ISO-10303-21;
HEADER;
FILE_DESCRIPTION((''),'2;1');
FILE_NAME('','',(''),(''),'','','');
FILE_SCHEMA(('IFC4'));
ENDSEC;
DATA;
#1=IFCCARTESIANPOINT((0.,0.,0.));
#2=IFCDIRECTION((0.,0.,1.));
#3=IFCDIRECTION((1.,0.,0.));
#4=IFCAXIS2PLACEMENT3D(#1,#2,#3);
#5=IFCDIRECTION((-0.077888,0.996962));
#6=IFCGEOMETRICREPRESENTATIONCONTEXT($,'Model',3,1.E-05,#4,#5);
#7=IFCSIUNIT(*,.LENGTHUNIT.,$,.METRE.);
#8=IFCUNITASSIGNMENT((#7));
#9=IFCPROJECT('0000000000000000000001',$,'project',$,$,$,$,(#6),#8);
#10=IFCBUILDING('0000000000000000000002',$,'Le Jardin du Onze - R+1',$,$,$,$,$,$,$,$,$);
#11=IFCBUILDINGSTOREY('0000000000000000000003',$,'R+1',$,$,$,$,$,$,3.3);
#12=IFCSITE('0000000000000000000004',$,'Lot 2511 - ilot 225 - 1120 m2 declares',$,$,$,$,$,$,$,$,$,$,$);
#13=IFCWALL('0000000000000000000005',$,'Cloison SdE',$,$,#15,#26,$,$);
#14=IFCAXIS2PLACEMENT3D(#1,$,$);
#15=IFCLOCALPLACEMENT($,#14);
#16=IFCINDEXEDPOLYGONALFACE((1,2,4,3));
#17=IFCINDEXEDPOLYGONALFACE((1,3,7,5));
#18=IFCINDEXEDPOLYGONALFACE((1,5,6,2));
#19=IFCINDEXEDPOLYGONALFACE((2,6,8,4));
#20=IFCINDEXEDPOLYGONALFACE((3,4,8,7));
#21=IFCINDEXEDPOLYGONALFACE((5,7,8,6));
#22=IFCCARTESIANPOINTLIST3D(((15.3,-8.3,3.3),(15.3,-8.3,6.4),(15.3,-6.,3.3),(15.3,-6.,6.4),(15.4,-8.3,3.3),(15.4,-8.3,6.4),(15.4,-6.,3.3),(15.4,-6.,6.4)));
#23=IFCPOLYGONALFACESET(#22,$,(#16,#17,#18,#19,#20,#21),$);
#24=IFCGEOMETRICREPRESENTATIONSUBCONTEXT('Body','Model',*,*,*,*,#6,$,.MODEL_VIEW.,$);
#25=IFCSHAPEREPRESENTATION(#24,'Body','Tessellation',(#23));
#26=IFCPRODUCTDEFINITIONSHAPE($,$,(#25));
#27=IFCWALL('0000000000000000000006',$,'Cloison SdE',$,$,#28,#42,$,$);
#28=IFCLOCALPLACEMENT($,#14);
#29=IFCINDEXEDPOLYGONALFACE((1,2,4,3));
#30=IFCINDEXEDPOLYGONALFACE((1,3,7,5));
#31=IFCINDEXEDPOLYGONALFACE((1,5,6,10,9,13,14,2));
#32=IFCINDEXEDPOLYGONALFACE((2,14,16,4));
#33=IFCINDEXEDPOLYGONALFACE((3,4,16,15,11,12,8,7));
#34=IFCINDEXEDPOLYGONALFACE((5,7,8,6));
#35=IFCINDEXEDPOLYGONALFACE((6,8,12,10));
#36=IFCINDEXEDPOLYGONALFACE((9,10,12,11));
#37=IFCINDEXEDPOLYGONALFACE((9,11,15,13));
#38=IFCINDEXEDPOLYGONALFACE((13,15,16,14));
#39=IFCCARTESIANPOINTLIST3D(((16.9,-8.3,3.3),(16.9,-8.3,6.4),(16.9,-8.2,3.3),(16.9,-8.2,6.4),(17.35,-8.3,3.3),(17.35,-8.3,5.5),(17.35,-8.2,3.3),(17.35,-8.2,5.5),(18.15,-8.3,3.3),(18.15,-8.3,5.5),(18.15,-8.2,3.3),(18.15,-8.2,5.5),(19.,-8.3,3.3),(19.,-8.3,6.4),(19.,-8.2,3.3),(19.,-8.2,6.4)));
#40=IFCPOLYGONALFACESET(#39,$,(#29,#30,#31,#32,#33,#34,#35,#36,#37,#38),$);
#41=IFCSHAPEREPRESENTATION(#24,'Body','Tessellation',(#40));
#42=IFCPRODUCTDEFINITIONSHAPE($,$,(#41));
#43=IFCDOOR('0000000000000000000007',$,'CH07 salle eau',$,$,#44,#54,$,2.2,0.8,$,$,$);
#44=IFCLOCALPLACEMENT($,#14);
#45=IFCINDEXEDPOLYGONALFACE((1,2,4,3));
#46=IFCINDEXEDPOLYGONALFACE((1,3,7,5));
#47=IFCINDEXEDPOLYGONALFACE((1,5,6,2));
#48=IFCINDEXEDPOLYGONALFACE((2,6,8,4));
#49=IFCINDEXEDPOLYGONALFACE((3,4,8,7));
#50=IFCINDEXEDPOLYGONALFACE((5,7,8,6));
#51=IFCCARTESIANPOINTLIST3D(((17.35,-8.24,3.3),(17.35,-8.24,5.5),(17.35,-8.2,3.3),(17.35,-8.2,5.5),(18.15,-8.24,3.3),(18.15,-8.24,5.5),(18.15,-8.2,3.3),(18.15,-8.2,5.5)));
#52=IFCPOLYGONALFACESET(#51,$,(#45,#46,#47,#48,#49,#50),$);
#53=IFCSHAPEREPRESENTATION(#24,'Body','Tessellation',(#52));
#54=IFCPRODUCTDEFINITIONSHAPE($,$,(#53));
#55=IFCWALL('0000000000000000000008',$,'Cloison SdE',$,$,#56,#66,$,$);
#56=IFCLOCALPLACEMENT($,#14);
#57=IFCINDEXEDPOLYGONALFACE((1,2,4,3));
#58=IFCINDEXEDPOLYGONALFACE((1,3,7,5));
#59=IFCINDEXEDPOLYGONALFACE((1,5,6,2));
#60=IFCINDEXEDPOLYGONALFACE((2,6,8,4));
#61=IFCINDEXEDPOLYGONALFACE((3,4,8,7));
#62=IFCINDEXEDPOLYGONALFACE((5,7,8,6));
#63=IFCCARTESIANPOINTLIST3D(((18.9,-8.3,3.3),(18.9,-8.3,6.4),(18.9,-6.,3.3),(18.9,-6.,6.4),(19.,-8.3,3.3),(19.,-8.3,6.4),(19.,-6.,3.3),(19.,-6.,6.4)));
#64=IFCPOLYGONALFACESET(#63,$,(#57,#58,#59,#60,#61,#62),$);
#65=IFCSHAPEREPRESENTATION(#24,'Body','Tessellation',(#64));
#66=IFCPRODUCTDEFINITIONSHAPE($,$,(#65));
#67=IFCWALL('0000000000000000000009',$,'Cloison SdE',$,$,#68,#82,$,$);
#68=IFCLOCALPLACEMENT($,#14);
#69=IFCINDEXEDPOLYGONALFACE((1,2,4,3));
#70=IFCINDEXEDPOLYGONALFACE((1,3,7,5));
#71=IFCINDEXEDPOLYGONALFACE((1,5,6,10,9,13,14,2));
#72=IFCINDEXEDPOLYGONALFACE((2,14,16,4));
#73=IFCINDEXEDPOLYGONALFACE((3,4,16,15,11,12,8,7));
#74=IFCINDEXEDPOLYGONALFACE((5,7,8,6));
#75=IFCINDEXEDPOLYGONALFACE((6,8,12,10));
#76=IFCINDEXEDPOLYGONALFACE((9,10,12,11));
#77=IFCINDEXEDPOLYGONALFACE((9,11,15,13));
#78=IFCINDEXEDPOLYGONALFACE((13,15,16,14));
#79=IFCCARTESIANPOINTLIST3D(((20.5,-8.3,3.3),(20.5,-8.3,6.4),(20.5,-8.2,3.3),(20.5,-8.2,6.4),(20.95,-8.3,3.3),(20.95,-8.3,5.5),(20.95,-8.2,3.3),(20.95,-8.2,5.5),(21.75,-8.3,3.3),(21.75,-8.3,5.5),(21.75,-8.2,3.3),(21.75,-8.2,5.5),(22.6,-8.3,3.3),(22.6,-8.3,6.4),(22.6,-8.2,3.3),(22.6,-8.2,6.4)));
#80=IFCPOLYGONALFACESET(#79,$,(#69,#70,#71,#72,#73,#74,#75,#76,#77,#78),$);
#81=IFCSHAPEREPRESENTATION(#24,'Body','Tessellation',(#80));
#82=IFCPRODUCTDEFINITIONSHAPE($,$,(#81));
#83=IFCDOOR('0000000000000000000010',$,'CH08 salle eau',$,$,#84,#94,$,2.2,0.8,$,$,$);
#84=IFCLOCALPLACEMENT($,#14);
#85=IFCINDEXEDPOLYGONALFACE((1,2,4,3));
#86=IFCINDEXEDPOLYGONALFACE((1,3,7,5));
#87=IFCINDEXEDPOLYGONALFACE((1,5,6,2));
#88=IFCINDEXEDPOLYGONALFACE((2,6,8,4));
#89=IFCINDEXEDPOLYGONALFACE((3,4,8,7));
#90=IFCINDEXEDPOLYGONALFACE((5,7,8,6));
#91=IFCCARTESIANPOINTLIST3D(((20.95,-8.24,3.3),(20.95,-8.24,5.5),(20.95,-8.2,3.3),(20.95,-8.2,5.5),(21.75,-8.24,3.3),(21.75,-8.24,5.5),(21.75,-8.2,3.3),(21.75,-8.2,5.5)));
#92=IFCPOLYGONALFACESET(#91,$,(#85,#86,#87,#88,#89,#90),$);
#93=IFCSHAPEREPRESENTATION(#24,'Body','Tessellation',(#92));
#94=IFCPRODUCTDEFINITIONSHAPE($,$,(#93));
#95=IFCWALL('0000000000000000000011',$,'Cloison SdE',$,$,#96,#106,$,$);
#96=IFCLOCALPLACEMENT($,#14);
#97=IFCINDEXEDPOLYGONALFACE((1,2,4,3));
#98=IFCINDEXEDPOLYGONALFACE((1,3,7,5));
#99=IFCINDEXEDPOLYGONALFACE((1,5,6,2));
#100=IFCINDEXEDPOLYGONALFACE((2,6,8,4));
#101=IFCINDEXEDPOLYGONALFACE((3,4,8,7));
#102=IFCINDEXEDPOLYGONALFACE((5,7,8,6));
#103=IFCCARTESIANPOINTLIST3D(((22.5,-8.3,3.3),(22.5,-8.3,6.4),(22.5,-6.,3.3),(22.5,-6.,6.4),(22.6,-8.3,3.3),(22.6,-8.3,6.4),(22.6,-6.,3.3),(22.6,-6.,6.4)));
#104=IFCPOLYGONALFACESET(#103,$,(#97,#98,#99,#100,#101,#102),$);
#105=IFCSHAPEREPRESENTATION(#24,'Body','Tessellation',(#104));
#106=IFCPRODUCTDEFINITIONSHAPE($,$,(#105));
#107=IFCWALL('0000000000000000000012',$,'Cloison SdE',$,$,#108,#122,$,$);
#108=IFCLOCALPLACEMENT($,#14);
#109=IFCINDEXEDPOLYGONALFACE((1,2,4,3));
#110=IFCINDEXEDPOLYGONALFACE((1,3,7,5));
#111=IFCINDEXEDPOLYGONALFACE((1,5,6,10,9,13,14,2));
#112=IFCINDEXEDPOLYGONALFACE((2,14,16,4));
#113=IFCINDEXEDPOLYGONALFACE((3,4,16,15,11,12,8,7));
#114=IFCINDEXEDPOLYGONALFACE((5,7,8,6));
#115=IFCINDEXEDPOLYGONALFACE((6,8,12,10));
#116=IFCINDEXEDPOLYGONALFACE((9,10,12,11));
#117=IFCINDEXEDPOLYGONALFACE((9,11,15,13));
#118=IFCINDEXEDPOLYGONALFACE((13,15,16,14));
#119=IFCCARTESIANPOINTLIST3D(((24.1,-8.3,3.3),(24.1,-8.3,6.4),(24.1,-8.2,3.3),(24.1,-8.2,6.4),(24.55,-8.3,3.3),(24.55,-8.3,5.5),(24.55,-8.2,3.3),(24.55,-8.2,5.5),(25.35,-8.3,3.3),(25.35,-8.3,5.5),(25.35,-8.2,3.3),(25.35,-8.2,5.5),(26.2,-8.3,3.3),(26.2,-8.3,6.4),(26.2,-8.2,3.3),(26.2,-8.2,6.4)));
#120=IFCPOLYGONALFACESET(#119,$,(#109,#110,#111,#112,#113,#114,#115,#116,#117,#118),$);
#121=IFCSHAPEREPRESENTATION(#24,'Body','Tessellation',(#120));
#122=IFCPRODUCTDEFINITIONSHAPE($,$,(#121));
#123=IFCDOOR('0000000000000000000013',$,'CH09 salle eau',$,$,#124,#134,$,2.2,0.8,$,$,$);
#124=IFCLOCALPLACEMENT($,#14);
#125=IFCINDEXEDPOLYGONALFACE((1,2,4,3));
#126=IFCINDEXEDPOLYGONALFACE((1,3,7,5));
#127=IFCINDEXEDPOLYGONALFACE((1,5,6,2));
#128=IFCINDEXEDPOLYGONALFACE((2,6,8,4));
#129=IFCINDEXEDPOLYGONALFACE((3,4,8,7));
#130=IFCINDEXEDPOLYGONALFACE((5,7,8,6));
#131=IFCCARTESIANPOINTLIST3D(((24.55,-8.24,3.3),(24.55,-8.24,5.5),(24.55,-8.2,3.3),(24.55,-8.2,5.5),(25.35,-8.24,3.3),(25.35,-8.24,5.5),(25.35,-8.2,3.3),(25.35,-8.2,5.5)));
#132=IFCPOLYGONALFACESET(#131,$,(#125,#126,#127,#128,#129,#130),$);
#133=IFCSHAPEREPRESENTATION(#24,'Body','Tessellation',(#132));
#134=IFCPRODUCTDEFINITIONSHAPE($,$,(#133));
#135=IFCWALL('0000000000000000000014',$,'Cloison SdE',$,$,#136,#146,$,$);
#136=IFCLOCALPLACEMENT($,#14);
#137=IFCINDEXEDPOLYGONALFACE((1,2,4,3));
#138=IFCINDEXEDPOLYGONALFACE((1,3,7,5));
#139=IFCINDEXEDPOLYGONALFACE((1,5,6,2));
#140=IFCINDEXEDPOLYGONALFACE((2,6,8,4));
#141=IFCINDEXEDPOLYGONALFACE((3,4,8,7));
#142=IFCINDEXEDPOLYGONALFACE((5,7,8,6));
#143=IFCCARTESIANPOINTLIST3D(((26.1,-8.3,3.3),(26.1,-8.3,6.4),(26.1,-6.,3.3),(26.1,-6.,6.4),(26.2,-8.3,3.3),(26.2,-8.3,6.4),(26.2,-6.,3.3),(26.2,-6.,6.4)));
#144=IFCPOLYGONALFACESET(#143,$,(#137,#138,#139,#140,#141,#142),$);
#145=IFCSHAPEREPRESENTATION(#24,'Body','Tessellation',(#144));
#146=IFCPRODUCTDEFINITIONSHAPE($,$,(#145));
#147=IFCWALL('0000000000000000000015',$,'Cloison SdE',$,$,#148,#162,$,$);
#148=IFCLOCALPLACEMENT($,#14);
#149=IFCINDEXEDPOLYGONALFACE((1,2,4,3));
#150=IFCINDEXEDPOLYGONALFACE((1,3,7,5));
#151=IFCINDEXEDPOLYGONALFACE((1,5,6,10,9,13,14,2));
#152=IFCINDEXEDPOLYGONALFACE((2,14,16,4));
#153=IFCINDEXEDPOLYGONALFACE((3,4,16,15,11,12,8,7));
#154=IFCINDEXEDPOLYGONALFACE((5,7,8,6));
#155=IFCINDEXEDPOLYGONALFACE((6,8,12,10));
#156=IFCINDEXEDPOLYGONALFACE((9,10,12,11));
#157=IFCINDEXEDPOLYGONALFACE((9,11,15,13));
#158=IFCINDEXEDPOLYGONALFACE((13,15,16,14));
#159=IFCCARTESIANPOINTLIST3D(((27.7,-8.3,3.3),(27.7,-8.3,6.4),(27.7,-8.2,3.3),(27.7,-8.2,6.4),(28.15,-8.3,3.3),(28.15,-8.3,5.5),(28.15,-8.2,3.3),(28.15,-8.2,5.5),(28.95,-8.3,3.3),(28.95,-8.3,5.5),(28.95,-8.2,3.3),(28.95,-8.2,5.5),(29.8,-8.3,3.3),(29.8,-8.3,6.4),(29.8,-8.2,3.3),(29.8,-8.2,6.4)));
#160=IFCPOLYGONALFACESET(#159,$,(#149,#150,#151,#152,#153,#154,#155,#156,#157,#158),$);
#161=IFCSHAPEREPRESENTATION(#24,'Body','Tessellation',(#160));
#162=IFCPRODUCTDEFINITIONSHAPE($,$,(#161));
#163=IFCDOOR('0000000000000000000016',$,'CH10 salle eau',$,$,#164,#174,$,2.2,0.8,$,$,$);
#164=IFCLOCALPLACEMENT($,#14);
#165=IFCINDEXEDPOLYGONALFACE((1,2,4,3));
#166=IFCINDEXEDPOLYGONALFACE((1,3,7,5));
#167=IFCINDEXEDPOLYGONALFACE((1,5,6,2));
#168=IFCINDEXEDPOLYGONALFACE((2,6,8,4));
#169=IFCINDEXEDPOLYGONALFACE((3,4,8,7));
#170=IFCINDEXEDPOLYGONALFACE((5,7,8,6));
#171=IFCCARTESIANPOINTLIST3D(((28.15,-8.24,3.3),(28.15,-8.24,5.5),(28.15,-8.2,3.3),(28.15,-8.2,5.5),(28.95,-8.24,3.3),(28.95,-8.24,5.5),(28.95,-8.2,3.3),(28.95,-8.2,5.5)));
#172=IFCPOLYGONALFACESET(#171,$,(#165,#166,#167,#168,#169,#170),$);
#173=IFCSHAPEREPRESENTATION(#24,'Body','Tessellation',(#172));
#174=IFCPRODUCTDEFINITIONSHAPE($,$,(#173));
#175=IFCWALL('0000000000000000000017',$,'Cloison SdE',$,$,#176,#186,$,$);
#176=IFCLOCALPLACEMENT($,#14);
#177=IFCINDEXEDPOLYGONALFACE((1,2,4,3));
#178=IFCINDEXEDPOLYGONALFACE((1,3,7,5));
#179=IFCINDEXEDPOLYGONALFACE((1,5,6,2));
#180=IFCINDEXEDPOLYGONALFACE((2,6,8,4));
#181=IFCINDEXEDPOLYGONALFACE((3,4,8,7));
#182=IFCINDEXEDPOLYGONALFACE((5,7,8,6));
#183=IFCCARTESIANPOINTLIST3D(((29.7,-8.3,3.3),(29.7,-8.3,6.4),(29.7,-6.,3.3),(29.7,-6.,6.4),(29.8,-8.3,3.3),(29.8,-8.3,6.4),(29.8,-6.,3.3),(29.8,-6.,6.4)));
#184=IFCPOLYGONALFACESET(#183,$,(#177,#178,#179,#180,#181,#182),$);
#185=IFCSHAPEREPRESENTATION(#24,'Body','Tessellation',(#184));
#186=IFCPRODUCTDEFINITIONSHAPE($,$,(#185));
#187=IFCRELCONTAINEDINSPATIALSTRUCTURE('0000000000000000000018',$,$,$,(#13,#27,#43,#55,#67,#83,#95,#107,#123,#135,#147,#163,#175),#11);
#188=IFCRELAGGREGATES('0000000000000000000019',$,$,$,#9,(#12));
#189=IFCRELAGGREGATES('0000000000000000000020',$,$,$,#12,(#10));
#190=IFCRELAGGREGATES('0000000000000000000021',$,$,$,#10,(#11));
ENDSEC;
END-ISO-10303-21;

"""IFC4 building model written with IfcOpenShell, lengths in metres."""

from ifc_helpers import new_model, si_unit, direction, frame, origin_with_axes, place, context, subcontext, project, spatial, polyline, outline, extrude, element, fill, save


model = new_model("IFC4")

# Units and contexts
model_context = context("Model", 3, precision=1e-05, world=origin_with_axes(), true_north=direction((-0.077888, 0.996962)))
body_context = subcontext(model_context, "Body", "Model", "MODEL_VIEW")
ifc_project = project(units=[si_unit("LENGTHUNIT", "METRE")], contexts=[model_context])

# Site, building, storey
site = spatial("IfcSite", under=ifc_project, Name="Lot 2511 - ilot 225 - 1120 m2 declares")
building = spatial("IfcBuilding", under=site, Name="Le Jardin du Onze - R+1")
storey = spatial("IfcBuildingStorey", under=building, Name="R+1", Elevation=3.3)

# Wall
wall_1_placement = place(None, origin_with_axes())
element("IfcWall", 1, at=wall_1_placement, inside=storey, Name="Cloison SdE", context=body_context, shape_type="SweptSolid", body=[
    extrude(outline(polyline([(15.4, -8.3), (15.4, -6.0), (15.3, -6.0), (15.3, -8.3), (15.4, -8.3)])), frame((0.0, 0.0, 3.3)), (0.0, 0.0, 1.0), 3.1),
])

# Wall, opening, door
wall_2_placement = place(None, origin_with_axes())
wall_2 = element("IfcWall", 2, at=wall_2_placement, inside=storey, Name="Cloison SdE", context=body_context, shape_type="SweptSolid", body=[
    extrude(outline(polyline([(19.0, -8.3), (19.0, -8.2), (16.9, -8.2), (16.9, -8.3), (19.0, -8.3)])), frame((0.0, 0.0, 3.3)), (0.0, 0.0, 1.0), 3.1),
])
opening_1_placement = place(None, origin_with_axes())
opening_1 = element("IfcOpeningElement", 3, at=opening_1_placement, cuts=wall_2, context=body_context, shape_type="SweptSolid", body=[
    extrude(outline(polyline([(18.15, -8.34), (18.15, -8.06), (17.35, -8.06), (17.35, -8.34), (18.15, -8.34)])), frame((0.0, 0.0, 3.3)), (0.0, 0.0, 1.0), 2.2),
])
door_1_placement = place(None, origin_with_axes())
door_1 = element("IfcDoor", 4, at=door_1_placement, inside=storey, Name="CH07 salle eau", OverallHeight=2.2, OverallWidth=0.8, context=body_context, shape_type="SweptSolid", body=[
    extrude(outline(polyline([(18.15, -8.24), (18.15, -8.2), (17.35, -8.2), (17.35, -8.24), (18.15, -8.24)])), frame((0.0, 0.0, 3.3)), (0.0, 0.0, 1.0), 2.2),
])
fill(opening_1, door_1)

# Wall
wall_3_placement = place(None, origin_with_axes())
element("IfcWall", 5, at=wall_3_placement, inside=storey, Name="Cloison SdE", context=body_context, shape_type="SweptSolid", body=[
    extrude(outline(polyline([(19.0, -8.3), (19.0, -6.0), (18.9, -6.0), (18.9, -8.3), (19.0, -8.3)])), frame((0.0, 0.0, 3.3)), (0.0, 0.0, 1.0), 3.1),
])

# Wall, opening, door
wall_4_placement = place(None, origin_with_axes())
wall_4 = element("IfcWall", 6, at=wall_4_placement, inside=storey, Name="Cloison SdE", context=body_context, shape_type="SweptSolid", body=[
    extrude(outline(polyline([(22.6, -8.3), (22.6, -8.2), (20.5, -8.2), (20.5, -8.3), (22.6, -8.3)])), frame((0.0, 0.0, 3.3)), (0.0, 0.0, 1.0), 3.1),
])
opening_2_placement = place(None, origin_with_axes())
opening_2 = element("IfcOpeningElement", 7, at=opening_2_placement, cuts=wall_4, context=body_context, shape_type="SweptSolid", body=[
    extrude(outline(polyline([(21.75, -8.34), (21.75, -8.06), (20.95, -8.06), (20.95, -8.34), (21.75, -8.34)])), frame((0.0, 0.0, 3.3)), (0.0, 0.0, 1.0), 2.2),
])
door_2_placement = place(None, origin_with_axes())
door_2 = element("IfcDoor", 8, at=door_2_placement, inside=storey, Name="CH08 salle eau", OverallHeight=2.2, OverallWidth=0.8, context=body_context, shape_type="SweptSolid", body=[
    extrude(outline(polyline([(21.75, -8.24), (21.75, -8.2), (20.95, -8.2), (20.95, -8.24), (21.75, -8.24)])), frame((0.0, 0.0, 3.3)), (0.0, 0.0, 1.0), 2.2),
])
fill(opening_2, door_2)

# Wall
wall_5_placement = place(None, origin_with_axes())
element("IfcWall", 9, at=wall_5_placement, inside=storey, Name="Cloison SdE", context=body_context, shape_type="SweptSolid", body=[
    extrude(outline(polyline([(22.6, -8.3), (22.6, -6.0), (22.5, -6.0), (22.5, -8.3), (22.6, -8.3)])), frame((0.0, 0.0, 3.3)), (0.0, 0.0, 1.0), 3.1),
])

# Wall, opening, door
wall_6_placement = place(None, origin_with_axes())
wall_6 = element("IfcWall", 10, at=wall_6_placement, inside=storey, Name="Cloison SdE", context=body_context, shape_type="SweptSolid", body=[
    extrude(outline(polyline([(26.2, -8.3), (26.2, -8.2), (24.1, -8.2), (24.1, -8.3), (26.2, -8.3)])), frame((0.0, 0.0, 3.3)), (0.0, 0.0, 1.0), 3.1),
])
opening_3_placement = place(None, origin_with_axes())
opening_3 = element("IfcOpeningElement", 11, at=opening_3_placement, cuts=wall_6, context=body_context, shape_type="SweptSolid", body=[
    extrude(outline(polyline([(25.35, -8.34), (25.35, -8.06), (24.55, -8.06), (24.55, -8.34), (25.35, -8.34)])), frame((0.0, 0.0, 3.3)), (0.0, 0.0, 1.0), 2.2),
])
door_3_placement = place(None, origin_with_axes())
door_3 = element("IfcDoor", 12, at=door_3_placement, inside=storey, Name="CH09 salle eau", OverallHeight=2.2, OverallWidth=0.8, context=body_context, shape_type="SweptSolid", body=[
    extrude(outline(polyline([(25.35, -8.24), (25.35, -8.2), (24.55, -8.2), (24.55, -8.24), (25.35, -8.24)])), frame((0.0, 0.0, 3.3)), (0.0, 0.0, 1.0), 2.2),
])
fill(opening_3, door_3)

# Wall
wall_7_placement = place(None, origin_with_axes())
element("IfcWall", 13, at=wall_7_placement, inside=storey, Name="Cloison SdE", context=body_context, shape_type="SweptSolid", body=[
    extrude(outline(polyline([(26.2, -8.3), (26.2, -6.0), (26.1, -6.0), (26.1, -8.3), (26.2, -8.3)])), frame((0.0, 0.0, 3.3)), (0.0, 0.0, 1.0), 3.1),
])

# Wall, opening, door
wall_8_placement = place(None, origin_with_axes())
wall_8 = element("IfcWall", 14, at=wall_8_placement, inside=storey, Name="Cloison SdE", context=body_context, shape_type="SweptSolid", body=[
    extrude(outline(polyline([(29.8, -8.3), (29.8, -8.2), (27.7, -8.2), (27.7, -8.3), (29.8, -8.3)])), frame((0.0, 0.0, 3.3)), (0.0, 0.0, 1.0), 3.1),
])
opening_4_placement = place(None, origin_with_axes())
opening_4 = element("IfcOpeningElement", 15, at=opening_4_placement, cuts=wall_8, context=body_context, shape_type="SweptSolid", body=[
    extrude(outline(polyline([(28.95, -8.34), (28.95, -8.06), (28.15, -8.06), (28.15, -8.34), (28.95, -8.34)])), frame((0.0, 0.0, 3.3)), (0.0, 0.0, 1.0), 2.2),
])
door_4_placement = place(None, origin_with_axes())
door_4 = element("IfcDoor", 16, at=door_4_placement, inside=storey, Name="CH10 salle eau", OverallHeight=2.2, OverallWidth=0.8, context=body_context, shape_type="SweptSolid", body=[
    extrude(outline(polyline([(28.95, -8.24), (28.95, -8.2), (28.15, -8.2), (28.15, -8.24), (28.95, -8.24)])), frame((0.0, 0.0, 3.3)), (0.0, 0.0, 1.0), 2.2),
])
fill(opening_4, door_4)

# Wall
wall_9_placement = place(None, origin_with_axes())
element("IfcWall", 17, at=wall_9_placement, inside=storey, Name="Cloison SdE", context=body_context, shape_type="SweptSolid", body=[
    extrude(outline(polyline([(29.8, -8.3), (29.8, -6.0), (29.7, -6.0), (29.7, -8.3), (29.8, -8.3)])), frame((0.0, 0.0, 3.3)), (0.0, 0.0, 1.0), 3.1),
])

save(model, "model.ifc")
